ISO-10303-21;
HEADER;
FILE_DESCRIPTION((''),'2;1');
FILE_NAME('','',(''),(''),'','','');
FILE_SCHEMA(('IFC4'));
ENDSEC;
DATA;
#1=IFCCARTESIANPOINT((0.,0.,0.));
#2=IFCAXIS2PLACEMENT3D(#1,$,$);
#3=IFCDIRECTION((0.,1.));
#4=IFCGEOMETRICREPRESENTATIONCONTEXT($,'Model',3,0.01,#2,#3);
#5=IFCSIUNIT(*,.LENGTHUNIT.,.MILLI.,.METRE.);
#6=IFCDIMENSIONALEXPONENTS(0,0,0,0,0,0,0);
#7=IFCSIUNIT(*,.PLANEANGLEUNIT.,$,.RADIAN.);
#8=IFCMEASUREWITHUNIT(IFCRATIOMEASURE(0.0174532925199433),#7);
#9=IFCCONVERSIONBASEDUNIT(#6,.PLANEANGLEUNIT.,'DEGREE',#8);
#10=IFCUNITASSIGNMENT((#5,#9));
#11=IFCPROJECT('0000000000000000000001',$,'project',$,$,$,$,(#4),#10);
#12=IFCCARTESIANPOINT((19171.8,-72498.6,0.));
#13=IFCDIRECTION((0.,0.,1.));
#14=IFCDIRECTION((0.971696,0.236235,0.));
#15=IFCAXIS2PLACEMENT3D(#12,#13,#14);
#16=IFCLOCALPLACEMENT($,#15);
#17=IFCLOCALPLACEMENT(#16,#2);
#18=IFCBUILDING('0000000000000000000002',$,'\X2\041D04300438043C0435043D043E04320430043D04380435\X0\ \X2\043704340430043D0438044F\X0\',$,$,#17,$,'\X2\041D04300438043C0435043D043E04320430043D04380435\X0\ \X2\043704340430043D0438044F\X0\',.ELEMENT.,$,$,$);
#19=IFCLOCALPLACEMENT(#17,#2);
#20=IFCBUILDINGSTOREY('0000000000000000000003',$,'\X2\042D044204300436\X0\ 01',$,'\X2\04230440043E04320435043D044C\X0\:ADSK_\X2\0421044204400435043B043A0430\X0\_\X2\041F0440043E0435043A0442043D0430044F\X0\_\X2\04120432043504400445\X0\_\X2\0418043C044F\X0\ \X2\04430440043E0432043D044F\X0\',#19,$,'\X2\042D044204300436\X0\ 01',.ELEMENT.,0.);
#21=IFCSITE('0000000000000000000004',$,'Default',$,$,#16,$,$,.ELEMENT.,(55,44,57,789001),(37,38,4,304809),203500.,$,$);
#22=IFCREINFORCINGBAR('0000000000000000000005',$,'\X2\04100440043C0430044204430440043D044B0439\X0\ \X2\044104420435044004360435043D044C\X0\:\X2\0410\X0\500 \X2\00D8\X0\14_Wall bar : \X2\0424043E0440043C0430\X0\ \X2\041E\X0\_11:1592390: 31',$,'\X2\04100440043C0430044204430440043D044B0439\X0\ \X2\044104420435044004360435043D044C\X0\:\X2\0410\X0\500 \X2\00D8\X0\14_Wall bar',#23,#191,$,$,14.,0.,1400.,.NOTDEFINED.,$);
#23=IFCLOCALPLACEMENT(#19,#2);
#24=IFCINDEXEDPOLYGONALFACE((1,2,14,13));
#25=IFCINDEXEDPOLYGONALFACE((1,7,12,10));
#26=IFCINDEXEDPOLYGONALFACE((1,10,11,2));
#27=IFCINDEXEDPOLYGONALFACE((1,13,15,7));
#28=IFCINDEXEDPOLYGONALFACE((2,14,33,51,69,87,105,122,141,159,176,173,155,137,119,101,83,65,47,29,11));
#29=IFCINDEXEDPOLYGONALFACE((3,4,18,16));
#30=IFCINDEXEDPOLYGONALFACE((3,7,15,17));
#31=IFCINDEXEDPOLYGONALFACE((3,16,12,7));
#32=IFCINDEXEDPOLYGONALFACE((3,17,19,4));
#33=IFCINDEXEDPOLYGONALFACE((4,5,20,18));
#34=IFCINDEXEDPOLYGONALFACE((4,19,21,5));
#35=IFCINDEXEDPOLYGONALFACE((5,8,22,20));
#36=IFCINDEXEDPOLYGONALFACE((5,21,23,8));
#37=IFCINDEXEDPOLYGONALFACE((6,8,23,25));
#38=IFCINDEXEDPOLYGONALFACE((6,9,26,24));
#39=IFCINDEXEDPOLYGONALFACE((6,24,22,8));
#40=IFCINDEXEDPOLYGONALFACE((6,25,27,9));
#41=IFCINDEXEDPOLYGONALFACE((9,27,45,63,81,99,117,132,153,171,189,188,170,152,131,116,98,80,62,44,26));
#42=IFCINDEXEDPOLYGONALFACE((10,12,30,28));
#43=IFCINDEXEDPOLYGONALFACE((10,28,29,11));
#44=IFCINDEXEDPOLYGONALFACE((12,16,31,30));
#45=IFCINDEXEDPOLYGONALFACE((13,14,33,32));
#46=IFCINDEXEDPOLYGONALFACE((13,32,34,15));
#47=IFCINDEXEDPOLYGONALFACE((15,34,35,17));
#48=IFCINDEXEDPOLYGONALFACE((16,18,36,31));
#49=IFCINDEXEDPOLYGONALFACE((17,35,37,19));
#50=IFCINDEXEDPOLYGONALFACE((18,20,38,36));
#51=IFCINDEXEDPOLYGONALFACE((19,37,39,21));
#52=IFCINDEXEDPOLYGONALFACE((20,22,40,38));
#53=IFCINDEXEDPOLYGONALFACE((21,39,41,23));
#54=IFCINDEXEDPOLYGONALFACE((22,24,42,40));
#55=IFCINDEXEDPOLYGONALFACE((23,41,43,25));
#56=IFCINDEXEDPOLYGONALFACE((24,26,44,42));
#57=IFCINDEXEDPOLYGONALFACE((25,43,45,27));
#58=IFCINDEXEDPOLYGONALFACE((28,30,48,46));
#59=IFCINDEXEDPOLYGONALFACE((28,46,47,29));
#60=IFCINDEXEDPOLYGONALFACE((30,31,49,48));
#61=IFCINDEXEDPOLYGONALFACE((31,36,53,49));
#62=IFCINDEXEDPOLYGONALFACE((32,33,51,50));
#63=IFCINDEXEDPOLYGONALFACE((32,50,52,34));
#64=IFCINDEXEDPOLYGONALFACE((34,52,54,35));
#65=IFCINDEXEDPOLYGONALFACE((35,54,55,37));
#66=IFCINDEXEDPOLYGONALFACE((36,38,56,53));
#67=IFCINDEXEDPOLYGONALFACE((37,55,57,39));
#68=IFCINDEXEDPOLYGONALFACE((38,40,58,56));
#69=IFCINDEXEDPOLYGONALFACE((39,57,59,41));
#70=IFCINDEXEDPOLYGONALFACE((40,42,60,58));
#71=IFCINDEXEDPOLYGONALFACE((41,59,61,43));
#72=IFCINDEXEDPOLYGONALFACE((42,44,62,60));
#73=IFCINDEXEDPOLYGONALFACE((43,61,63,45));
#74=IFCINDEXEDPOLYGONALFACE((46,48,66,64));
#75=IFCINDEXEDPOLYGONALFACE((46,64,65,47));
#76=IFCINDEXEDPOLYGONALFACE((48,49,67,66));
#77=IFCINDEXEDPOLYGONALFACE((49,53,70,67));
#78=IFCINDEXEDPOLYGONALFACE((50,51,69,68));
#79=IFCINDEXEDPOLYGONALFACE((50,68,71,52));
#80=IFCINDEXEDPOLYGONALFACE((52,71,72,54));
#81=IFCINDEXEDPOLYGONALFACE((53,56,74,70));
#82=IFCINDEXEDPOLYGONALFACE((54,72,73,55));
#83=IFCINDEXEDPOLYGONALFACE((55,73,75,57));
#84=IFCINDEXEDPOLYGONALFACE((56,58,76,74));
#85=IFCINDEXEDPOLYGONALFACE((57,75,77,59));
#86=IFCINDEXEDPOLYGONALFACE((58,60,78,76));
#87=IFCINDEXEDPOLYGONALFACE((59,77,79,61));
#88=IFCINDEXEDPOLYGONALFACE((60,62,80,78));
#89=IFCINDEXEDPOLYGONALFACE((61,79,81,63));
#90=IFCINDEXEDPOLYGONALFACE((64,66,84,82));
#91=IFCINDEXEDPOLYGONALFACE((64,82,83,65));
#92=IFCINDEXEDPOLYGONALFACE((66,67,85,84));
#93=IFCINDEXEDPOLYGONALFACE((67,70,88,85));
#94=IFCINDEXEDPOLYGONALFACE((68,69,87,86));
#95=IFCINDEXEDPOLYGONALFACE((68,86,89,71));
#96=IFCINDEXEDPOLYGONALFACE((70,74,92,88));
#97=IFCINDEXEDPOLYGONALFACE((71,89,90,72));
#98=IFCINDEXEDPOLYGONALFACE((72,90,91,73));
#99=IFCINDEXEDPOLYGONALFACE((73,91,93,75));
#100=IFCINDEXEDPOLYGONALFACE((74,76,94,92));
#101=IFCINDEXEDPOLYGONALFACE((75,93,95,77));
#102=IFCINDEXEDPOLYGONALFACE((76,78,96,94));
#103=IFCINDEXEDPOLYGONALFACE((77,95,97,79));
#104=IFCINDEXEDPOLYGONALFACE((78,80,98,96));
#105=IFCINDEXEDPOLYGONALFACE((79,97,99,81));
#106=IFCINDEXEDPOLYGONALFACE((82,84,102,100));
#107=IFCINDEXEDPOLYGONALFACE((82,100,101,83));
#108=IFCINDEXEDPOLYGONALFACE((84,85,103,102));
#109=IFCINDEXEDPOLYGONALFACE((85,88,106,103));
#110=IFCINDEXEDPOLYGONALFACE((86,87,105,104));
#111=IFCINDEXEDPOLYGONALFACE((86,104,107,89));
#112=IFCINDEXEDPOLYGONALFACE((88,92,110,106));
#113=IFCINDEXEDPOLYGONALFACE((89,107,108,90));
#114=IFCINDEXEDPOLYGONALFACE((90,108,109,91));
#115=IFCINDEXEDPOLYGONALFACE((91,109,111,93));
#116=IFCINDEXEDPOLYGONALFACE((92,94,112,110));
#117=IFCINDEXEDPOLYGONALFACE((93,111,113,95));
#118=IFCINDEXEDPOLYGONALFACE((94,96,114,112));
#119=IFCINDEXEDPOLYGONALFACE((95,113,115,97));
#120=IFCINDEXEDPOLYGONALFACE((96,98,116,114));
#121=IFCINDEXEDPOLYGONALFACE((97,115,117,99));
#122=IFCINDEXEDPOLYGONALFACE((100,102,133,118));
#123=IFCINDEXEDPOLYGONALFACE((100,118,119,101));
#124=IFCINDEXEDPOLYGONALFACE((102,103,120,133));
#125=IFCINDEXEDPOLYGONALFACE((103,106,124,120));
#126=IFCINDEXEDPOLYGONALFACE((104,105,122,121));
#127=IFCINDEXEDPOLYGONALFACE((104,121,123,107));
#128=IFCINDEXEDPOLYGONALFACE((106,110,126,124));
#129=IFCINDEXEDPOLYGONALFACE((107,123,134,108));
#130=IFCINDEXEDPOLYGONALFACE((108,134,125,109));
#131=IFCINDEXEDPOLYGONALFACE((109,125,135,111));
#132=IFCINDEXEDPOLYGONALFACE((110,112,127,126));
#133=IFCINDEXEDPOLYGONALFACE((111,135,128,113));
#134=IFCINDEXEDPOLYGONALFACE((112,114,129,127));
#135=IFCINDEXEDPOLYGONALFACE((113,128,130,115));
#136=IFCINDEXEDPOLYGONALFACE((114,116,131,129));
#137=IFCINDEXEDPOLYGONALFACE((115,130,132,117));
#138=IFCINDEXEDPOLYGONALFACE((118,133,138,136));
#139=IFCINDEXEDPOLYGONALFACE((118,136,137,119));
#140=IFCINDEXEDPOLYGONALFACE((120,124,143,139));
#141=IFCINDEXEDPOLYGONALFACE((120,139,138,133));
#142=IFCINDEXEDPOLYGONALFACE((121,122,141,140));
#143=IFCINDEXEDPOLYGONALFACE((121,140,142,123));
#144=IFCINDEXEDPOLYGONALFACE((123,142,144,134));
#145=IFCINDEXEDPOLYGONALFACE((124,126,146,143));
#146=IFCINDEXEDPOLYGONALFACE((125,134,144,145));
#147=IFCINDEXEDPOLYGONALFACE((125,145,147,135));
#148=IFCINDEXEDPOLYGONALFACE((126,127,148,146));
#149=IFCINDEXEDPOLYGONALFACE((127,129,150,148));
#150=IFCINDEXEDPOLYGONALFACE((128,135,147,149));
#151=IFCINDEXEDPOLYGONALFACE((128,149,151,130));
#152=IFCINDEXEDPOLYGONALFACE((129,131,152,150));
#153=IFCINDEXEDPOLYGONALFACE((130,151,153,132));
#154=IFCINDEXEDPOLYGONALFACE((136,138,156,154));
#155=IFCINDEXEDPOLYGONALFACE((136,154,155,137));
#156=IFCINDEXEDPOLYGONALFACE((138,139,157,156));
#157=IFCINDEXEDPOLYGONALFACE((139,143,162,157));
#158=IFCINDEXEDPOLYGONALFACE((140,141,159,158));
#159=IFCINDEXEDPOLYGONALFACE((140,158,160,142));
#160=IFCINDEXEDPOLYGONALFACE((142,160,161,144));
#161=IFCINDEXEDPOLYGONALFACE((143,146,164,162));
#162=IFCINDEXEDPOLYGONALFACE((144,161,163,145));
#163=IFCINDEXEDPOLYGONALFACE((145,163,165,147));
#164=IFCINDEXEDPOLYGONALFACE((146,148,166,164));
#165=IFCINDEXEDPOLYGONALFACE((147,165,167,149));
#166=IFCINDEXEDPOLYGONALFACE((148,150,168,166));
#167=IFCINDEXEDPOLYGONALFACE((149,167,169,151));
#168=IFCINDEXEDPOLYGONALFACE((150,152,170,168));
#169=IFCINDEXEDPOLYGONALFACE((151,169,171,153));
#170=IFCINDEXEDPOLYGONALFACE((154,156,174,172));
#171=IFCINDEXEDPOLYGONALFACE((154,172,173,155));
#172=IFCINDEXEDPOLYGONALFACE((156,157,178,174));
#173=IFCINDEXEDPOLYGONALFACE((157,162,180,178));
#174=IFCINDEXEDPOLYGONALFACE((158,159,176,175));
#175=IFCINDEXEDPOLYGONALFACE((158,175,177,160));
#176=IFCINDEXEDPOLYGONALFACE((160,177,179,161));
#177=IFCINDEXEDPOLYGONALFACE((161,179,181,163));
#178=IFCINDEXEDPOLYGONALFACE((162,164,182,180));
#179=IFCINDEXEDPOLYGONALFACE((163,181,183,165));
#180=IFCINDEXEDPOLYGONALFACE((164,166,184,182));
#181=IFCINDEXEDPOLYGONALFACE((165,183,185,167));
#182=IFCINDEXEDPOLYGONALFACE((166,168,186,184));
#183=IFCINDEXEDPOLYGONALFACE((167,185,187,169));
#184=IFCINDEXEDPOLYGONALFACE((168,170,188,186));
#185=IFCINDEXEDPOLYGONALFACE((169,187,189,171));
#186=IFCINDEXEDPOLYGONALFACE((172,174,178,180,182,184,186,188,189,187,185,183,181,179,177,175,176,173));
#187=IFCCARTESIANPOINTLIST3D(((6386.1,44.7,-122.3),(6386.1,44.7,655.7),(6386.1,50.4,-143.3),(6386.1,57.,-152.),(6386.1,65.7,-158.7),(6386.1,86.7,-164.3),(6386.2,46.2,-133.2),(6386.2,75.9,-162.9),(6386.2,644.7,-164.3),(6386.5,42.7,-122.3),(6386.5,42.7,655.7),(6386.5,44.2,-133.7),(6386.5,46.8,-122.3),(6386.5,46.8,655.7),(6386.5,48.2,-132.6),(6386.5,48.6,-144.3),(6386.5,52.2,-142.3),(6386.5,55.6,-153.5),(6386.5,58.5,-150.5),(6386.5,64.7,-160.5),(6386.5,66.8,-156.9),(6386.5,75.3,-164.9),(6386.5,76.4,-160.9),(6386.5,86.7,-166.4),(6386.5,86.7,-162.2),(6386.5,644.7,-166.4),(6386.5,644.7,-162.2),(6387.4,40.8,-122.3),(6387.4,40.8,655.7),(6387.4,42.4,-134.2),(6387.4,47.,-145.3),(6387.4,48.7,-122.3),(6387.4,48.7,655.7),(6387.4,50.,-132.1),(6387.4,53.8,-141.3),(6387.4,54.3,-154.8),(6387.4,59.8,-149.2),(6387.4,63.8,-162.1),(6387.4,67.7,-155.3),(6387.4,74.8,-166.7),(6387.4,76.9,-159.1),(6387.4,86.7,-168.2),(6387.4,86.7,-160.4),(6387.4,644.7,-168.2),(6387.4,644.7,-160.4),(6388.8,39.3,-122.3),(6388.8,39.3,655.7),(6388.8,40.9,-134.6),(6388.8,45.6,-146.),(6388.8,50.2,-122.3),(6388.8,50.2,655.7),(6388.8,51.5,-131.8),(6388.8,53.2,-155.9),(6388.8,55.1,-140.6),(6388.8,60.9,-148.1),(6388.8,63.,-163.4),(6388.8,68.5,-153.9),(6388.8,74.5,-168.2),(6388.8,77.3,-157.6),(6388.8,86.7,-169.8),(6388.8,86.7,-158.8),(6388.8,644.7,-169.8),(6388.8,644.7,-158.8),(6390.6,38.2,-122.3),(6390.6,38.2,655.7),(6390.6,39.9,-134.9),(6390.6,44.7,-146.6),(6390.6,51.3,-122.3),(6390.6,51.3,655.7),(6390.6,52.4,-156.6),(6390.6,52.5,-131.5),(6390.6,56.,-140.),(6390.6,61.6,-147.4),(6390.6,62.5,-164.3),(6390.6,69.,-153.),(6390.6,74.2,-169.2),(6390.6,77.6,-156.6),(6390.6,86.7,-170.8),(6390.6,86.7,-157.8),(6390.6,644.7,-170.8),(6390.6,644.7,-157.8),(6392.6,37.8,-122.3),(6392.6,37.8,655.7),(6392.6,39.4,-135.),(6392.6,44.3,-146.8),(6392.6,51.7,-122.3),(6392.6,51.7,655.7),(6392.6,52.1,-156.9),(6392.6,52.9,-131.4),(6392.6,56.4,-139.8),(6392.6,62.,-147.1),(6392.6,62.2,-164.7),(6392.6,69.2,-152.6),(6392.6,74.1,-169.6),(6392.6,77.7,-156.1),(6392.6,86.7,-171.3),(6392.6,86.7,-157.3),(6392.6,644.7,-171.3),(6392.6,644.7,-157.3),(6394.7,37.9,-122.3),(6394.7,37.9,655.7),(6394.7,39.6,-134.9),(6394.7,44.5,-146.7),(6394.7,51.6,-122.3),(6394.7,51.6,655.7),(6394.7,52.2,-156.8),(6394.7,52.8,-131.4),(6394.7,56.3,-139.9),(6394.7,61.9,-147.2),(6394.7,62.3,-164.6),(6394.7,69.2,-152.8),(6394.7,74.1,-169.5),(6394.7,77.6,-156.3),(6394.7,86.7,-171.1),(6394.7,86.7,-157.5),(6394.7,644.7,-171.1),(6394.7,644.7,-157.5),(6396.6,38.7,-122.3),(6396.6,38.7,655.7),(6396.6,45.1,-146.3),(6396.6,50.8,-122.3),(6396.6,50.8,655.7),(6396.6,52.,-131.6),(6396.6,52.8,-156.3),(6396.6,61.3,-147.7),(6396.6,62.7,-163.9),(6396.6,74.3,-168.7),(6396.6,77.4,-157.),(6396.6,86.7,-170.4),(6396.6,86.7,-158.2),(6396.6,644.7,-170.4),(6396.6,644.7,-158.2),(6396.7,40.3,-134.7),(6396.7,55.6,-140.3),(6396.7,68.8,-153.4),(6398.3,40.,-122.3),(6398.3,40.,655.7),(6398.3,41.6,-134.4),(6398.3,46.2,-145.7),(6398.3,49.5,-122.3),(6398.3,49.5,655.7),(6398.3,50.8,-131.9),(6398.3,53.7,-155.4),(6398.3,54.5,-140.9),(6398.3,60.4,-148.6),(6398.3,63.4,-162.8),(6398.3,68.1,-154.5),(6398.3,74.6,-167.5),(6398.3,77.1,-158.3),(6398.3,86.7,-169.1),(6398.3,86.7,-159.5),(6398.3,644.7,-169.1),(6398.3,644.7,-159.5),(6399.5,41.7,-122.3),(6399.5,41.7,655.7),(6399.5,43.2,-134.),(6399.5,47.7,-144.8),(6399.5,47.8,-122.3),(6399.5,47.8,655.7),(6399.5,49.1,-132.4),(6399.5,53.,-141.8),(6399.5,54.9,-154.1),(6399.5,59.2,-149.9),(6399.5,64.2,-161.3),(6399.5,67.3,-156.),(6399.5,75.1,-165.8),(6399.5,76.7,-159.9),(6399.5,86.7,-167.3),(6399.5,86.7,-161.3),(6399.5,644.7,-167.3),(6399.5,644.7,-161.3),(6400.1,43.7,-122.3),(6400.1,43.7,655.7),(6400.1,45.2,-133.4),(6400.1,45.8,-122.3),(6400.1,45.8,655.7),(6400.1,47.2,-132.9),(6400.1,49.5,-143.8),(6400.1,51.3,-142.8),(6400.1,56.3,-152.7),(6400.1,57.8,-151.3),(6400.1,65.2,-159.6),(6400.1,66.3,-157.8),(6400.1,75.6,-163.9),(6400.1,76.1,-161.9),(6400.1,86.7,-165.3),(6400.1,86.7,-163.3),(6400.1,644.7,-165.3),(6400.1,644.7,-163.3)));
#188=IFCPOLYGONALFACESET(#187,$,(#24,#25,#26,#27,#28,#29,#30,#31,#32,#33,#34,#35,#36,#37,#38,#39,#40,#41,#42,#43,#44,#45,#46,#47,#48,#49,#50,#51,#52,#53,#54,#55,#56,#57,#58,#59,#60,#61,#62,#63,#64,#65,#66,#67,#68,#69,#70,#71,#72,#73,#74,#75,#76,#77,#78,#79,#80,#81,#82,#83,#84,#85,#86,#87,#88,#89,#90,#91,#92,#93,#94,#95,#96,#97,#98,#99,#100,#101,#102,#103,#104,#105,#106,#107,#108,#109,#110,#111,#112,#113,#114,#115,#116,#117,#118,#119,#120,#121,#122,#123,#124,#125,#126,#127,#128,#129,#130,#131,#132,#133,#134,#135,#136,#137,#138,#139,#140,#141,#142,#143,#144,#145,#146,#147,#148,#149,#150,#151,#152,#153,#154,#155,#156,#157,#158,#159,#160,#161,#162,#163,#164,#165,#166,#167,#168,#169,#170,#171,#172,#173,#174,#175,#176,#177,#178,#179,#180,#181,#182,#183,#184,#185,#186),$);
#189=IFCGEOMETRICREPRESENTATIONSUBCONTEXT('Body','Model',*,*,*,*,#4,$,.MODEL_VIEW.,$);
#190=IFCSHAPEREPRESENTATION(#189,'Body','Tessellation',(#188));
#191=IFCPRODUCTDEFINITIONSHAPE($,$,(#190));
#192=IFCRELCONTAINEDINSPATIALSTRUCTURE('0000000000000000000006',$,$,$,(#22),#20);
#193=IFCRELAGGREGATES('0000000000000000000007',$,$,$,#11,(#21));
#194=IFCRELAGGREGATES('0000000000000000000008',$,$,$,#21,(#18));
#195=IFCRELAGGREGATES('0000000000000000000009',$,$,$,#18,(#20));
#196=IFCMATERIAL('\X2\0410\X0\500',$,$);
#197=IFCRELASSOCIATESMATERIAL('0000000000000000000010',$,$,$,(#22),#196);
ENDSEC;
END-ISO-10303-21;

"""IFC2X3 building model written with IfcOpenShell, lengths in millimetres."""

from ifc_helpers import new_model, entity, si_unit, converted_unit, direction, frame, origin, place, context, subcontext, project, spatial, material, element, save


model = new_model("IFC2X3")

# Units and contexts
model_context = context("Model", 3, precision=0.01, world=origin(), true_north=direction((0.0, 1.0)))
body_context = subcontext(model_context, "Body", "Model", "MODEL_VIEW")
ifc_project = project(units=[si_unit("LENGTHUNIT", "METRE", prefix="MILLI"), converted_unit("PLANEANGLEUNIT", "DEGREE", entity("IfcRatioMeasure", 0.0174532925199433), si_unit("PLANEANGLEUNIT", "RADIAN"), dimensions=[0, 0, 0, 0, 0, 0, 0])], contexts=[model_context])

# Site, building, storey
site_placement = place(None, frame((19171.8, -72498.6, 0.0), z_axis=(0.0, 0.0, 1.0), x_axis=(0.971696, 0.236235, 0.0)))
site = spatial("IfcSite", under=ifc_project, at=site_placement, Name="Default", CompositionType="ELEMENT", RefLatitude=(55, 44, 57, 789001), RefLongitude=(37, 38, 4, 304809), RefElevation=203500.0)
building_placement = place(site_placement, origin())
building = spatial("IfcBuilding", under=site, at=building_placement, Name="Наименование здания", LongName="Наименование здания", CompositionType="ELEMENT")
storey_placement = place(building_placement, origin())
storey = spatial("IfcBuildingStorey", under=building, at=storey_placement, Name="Этаж 01", ObjectType="Уровень:ADSK_Стрелка_Проектная_Вверх_Имя уровня", LongName="Этаж 01", CompositionType="ELEMENT", Elevation=0.0)

# Reinforcing bar
ifc_material = material(Name="А500")
placement = place(storey_placement, origin())
element("IfcReinforcingBar", 1, at=placement, inside=storey, material=ifc_material, Name="Арматурный стержень:А500 Ø14_Wall bar : Форма О_11:1592390: 31", ObjectType="Арматурный стержень:А500 Ø14_Wall bar", BarLength=1400.0, BarRole="NOTDEFINED", CrossSectionArea=0.0, NominalDiameter=14.0, context=body_context, shape_type="AdvancedSweptSolid", body=[
    entity("IfcSweptDiskSolid", entity("IfcCompositeCurve", [entity("IfcCompositeCurveSegment", "CONTINUOUS", True, entity("IfcPolyline", [entity("IfcCartesianPoint", [6393.1, 44.7, 655.7]), entity("IfcCartesianPoint", [6393.1, 44.7, -122.3])])), entity("IfcCompositeCurveSegment", "CONTINUOUS", True, entity("IfcTrimmedCurve", entity("IfcCircle", entity("IfcAxis2Placement3D", entity("IfcCartesianPoint", [6393.1, 86.7, -122.3]), entity("IfcDirection", [1.0, 0.0, 0.0]), entity("IfcDirection", [0.0, 0.0, -1.0])), 42.0), [entity("IfcParameterValue", 270.0)], [entity("IfcParameterValue", 360.0)], True, "PARAMETER")), entity("IfcCompositeCurveSegment", "CONTINUOUS", True, entity("IfcPolyline", [entity("IfcCartesianPoint", [6393.1, 86.7, -164.3]), entity("IfcCartesianPoint", [6393.1, 644.7, -164.3])]))], False), 7.0, None, 0.0, 92.0),
])

save(model, "model.ifc")
